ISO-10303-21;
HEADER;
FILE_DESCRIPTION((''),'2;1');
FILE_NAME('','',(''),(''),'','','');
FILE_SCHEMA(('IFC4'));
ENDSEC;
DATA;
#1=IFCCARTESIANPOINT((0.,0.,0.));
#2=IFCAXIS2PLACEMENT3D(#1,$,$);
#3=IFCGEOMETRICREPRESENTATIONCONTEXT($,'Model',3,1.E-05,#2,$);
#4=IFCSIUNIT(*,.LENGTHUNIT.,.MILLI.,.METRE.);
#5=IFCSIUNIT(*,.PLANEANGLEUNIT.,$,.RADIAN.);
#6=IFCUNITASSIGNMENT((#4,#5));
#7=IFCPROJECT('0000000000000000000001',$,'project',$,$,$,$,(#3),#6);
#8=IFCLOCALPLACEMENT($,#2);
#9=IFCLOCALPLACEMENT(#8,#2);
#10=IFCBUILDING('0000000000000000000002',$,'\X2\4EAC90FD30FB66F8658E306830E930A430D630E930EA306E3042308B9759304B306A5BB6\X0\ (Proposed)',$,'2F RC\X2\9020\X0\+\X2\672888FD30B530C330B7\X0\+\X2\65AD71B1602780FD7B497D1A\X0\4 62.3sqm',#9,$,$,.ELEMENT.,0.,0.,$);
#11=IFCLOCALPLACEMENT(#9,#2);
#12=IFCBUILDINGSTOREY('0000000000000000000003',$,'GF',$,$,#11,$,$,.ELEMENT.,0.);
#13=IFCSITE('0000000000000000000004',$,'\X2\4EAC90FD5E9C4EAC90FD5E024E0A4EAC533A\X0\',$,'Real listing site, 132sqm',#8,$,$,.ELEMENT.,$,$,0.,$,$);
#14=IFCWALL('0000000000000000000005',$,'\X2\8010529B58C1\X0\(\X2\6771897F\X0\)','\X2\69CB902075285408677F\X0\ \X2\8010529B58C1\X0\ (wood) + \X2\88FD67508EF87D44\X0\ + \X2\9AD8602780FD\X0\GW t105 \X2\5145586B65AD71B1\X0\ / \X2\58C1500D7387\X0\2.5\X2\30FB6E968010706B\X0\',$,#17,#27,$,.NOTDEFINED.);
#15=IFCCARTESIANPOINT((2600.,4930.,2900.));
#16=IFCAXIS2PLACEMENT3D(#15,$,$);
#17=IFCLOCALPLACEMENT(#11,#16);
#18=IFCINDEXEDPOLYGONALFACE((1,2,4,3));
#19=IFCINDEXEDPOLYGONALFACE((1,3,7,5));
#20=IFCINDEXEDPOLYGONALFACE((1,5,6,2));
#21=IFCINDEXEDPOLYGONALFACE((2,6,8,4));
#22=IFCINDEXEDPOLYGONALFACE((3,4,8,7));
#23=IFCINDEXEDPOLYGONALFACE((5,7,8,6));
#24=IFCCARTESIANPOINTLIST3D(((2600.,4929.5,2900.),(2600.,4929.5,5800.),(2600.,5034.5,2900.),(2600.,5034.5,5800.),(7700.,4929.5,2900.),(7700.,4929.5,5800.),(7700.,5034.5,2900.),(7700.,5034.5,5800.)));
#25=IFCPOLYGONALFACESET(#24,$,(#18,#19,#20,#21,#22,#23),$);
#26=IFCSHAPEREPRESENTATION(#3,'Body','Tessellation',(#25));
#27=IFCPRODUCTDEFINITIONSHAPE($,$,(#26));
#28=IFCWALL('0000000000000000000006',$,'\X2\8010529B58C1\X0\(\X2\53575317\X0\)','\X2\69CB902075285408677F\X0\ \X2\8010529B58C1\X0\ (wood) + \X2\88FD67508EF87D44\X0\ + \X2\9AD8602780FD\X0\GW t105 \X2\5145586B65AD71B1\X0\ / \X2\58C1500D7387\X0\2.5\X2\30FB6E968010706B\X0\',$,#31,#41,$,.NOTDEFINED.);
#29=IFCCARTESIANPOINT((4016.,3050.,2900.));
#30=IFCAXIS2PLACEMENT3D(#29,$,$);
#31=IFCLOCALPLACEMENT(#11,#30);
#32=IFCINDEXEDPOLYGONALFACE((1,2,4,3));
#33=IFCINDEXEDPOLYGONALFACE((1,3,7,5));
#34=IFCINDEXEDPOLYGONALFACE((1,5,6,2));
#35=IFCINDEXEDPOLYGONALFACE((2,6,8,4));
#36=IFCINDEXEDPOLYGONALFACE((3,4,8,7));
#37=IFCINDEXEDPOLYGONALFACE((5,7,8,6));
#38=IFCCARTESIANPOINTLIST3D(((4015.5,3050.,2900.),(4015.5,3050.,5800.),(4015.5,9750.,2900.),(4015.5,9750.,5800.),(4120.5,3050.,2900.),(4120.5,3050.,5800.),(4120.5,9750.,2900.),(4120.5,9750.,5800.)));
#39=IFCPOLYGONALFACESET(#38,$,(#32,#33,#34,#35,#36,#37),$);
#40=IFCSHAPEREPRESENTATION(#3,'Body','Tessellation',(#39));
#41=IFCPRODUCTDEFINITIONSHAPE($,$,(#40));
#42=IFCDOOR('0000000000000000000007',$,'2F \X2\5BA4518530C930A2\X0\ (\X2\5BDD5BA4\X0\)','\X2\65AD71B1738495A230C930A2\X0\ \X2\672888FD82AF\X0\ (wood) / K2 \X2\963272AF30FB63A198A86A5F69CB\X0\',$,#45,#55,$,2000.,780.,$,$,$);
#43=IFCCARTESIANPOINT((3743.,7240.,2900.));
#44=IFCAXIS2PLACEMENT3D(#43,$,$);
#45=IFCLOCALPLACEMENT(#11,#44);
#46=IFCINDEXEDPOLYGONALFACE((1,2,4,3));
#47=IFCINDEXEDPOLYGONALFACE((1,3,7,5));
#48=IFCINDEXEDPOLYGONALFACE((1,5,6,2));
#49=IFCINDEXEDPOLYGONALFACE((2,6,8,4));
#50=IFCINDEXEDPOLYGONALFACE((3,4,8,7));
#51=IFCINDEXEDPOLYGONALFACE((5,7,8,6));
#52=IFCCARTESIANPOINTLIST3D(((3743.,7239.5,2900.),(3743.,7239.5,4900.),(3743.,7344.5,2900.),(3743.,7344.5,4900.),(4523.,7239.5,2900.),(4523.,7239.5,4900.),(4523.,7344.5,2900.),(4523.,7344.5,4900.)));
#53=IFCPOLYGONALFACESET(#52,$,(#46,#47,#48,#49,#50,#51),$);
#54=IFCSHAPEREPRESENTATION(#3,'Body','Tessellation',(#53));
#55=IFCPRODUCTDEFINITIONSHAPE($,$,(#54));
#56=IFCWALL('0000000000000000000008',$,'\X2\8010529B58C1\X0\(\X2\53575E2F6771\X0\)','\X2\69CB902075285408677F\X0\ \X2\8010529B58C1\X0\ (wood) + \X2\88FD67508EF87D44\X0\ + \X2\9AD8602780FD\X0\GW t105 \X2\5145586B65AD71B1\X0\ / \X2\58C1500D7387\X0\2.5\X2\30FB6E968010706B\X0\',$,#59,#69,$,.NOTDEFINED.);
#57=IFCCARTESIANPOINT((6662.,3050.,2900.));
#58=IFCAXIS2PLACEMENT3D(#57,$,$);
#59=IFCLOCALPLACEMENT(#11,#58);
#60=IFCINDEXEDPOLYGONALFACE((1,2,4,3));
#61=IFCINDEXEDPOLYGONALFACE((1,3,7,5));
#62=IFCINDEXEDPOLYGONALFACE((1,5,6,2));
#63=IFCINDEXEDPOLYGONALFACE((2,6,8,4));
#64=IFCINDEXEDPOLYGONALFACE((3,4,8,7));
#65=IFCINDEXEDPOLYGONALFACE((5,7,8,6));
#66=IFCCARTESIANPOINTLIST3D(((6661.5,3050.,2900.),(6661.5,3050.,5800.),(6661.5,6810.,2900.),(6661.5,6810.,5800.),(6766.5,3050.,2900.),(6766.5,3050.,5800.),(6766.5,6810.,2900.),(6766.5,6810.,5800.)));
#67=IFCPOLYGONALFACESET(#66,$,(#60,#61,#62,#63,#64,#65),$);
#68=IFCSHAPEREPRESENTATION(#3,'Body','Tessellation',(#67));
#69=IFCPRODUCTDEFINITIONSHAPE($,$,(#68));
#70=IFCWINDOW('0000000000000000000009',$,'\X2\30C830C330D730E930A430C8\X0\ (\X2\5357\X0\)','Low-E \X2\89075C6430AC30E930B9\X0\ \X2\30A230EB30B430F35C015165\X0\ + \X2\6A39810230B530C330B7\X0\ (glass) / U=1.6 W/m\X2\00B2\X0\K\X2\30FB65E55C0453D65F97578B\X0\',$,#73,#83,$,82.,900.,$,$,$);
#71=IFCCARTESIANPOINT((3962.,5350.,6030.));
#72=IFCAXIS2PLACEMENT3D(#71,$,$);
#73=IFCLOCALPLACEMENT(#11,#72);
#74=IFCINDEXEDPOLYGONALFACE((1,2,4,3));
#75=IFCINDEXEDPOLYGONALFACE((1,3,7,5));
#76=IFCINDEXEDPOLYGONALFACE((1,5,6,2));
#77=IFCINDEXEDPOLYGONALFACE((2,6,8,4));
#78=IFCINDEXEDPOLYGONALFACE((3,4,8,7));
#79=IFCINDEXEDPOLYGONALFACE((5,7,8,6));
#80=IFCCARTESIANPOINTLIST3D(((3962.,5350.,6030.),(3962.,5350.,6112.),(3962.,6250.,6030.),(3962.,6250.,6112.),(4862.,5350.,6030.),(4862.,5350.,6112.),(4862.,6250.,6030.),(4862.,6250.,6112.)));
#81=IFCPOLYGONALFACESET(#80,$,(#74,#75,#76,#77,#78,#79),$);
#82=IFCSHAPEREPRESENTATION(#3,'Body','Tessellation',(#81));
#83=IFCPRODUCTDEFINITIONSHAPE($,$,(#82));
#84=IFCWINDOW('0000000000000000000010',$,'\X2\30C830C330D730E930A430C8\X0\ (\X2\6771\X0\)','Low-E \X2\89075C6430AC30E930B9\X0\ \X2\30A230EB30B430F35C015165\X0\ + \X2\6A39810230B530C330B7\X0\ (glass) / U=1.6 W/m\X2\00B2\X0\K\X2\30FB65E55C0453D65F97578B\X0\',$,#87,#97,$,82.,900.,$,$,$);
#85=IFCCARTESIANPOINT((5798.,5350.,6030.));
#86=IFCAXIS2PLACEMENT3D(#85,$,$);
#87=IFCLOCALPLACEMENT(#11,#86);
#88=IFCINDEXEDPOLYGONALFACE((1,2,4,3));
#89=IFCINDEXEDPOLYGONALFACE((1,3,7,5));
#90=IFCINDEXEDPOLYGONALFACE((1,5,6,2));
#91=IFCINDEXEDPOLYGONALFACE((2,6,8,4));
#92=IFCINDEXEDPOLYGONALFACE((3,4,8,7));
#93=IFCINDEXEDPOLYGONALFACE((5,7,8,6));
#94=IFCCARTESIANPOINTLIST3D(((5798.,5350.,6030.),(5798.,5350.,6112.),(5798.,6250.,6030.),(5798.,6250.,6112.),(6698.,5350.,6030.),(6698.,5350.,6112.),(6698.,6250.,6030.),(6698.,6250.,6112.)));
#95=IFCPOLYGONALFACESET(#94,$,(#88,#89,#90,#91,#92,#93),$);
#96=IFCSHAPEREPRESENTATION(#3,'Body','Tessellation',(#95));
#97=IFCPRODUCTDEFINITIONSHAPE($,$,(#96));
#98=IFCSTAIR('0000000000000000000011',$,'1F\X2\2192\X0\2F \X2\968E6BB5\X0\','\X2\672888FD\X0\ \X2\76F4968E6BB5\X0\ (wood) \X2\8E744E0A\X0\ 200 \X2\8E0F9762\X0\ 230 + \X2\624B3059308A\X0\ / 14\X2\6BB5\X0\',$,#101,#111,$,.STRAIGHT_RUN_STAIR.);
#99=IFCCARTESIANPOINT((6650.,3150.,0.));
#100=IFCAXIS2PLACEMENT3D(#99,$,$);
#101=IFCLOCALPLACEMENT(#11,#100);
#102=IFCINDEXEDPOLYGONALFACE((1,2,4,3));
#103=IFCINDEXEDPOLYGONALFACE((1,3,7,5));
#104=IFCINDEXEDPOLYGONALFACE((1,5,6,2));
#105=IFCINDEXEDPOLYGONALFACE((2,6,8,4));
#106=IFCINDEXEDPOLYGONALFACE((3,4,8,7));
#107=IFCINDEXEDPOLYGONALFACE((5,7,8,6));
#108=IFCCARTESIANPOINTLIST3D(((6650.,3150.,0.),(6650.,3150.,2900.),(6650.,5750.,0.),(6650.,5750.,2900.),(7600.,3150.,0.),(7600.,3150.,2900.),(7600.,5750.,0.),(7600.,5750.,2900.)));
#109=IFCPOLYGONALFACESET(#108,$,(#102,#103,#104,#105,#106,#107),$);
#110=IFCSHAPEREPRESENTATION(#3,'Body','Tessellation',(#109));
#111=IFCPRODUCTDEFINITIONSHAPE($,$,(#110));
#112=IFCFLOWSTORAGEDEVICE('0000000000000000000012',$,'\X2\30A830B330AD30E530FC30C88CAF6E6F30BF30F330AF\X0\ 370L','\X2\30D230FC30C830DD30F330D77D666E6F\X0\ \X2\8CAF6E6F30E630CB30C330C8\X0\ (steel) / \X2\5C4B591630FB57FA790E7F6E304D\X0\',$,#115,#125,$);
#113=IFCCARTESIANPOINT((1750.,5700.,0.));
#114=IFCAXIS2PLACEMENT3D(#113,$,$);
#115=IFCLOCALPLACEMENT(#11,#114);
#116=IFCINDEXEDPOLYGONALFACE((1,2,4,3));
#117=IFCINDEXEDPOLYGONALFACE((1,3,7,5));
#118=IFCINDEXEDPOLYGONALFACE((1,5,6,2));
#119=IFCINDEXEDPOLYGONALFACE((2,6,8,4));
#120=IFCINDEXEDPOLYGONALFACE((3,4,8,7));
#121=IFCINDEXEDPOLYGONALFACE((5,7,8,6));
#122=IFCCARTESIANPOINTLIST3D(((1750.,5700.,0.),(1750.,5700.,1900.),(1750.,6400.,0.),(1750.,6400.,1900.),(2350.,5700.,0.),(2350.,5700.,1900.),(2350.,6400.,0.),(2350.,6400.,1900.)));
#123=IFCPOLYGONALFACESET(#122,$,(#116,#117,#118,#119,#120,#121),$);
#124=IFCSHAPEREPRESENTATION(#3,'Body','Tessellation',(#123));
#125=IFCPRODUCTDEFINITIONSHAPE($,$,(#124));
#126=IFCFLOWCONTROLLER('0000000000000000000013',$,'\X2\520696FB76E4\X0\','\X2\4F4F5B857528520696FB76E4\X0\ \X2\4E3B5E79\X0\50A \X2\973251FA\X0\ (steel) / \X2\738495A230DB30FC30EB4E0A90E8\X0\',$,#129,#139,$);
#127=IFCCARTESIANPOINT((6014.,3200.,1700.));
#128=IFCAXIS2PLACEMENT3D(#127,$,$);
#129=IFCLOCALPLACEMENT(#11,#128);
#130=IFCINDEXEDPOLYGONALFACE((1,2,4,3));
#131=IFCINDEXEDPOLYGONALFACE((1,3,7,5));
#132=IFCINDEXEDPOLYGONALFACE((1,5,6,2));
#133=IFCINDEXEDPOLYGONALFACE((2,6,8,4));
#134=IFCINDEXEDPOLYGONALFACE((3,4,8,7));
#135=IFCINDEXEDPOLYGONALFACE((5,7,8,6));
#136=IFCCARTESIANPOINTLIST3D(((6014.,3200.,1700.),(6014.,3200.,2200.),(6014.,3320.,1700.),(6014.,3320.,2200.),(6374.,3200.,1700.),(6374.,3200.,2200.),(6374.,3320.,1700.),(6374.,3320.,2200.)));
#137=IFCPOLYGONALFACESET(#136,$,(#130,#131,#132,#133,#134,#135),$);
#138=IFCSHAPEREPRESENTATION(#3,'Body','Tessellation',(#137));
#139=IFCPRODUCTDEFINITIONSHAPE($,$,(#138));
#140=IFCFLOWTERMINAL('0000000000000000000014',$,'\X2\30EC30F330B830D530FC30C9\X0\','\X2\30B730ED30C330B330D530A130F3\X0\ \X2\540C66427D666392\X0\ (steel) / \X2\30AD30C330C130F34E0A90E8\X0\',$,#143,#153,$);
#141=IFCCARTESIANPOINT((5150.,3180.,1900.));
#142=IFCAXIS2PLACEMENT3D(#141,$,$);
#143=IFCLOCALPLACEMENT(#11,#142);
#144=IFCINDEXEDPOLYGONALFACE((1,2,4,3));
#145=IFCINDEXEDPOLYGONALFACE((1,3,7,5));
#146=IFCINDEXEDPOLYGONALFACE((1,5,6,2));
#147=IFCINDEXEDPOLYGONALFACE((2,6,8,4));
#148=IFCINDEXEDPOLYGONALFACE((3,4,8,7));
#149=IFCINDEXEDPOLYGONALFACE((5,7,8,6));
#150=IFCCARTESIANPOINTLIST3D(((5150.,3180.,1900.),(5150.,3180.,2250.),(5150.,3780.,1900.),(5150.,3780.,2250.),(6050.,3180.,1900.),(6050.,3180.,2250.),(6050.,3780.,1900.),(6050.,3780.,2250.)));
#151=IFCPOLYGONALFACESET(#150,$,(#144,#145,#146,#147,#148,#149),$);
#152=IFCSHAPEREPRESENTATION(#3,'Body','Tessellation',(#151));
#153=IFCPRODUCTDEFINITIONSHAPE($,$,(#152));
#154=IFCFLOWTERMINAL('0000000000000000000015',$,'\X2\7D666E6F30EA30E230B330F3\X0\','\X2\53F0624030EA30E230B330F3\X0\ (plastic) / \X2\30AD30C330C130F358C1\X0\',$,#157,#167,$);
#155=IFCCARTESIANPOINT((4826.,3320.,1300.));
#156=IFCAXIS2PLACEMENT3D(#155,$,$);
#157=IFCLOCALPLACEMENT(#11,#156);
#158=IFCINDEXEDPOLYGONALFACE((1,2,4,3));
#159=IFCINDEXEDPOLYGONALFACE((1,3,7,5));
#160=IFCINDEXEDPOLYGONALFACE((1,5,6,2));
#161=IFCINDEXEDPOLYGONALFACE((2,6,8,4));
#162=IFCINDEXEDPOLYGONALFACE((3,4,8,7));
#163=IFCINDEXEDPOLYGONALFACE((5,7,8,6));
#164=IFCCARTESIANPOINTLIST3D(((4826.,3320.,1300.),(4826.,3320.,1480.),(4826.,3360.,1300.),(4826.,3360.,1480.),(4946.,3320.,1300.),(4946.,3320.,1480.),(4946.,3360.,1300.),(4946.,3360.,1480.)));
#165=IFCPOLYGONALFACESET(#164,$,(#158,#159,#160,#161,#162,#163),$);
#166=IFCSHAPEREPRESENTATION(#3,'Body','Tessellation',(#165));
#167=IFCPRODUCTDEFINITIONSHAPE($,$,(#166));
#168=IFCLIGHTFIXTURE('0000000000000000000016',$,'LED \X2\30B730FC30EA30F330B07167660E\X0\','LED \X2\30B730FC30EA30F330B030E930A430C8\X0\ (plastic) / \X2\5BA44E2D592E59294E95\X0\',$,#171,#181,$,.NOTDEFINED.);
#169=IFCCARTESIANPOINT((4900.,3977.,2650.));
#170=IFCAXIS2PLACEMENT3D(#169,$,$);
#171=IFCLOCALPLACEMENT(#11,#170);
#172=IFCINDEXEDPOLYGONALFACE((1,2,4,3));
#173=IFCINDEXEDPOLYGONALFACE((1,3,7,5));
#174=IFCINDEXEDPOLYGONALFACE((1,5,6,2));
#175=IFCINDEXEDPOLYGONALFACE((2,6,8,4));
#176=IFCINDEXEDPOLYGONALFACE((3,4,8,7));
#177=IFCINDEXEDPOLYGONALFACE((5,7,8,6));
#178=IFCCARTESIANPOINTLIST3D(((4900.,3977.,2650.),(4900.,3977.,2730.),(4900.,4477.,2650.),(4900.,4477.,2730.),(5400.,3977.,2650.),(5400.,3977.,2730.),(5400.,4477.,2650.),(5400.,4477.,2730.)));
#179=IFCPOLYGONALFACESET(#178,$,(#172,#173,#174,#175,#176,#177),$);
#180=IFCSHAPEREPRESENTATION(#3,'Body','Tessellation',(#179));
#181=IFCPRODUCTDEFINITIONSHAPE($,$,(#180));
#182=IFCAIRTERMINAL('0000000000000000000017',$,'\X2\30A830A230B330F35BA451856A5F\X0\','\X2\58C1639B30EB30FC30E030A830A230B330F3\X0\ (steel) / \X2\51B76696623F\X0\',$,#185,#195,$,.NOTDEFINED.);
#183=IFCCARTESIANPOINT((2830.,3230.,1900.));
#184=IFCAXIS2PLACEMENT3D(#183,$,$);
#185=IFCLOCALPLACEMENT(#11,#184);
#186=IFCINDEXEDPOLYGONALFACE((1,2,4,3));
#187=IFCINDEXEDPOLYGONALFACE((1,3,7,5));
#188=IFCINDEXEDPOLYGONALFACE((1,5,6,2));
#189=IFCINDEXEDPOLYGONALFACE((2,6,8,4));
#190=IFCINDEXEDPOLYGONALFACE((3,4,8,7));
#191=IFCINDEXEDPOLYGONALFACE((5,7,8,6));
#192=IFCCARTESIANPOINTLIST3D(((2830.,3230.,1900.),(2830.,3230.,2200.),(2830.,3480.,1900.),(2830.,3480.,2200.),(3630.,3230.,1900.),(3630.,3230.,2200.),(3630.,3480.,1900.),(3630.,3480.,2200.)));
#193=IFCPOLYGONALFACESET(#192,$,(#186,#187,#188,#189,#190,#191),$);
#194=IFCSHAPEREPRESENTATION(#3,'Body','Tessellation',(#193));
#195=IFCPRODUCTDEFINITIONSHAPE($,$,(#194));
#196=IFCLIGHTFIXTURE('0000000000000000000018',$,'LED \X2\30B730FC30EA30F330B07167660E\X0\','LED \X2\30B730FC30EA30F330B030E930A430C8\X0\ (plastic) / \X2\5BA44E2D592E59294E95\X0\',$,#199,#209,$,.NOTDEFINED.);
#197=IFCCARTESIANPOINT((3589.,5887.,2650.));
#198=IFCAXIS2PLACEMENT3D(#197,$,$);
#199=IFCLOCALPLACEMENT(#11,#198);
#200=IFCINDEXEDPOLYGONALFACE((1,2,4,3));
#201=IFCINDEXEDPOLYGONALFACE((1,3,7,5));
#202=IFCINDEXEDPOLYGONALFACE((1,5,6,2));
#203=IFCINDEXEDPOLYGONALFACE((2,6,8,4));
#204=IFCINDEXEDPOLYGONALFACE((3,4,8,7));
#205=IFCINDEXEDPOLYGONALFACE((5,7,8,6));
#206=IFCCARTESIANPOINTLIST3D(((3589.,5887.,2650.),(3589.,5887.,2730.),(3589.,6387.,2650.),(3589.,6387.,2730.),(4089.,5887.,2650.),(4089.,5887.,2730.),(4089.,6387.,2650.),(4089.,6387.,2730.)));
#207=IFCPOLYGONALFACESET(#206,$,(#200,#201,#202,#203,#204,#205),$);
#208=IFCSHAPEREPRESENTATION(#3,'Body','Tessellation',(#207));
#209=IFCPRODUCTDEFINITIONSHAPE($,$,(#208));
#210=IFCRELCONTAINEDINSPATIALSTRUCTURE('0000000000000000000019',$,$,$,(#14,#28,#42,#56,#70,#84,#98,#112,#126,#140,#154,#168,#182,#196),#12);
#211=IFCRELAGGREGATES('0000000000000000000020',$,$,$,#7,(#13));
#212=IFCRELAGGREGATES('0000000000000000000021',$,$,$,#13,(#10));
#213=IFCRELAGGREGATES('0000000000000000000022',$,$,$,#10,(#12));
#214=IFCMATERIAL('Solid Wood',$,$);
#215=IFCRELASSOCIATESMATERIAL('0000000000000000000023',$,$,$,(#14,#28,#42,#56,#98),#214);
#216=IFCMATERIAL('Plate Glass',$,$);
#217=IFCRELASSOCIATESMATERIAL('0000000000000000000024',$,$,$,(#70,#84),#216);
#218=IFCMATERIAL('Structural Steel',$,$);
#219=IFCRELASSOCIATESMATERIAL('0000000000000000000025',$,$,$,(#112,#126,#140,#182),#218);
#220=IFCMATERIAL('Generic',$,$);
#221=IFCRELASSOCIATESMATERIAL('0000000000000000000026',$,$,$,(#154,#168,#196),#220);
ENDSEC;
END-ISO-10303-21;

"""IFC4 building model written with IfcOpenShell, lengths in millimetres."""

from ifc_helpers import new_model, si_unit, frame, frame_2d, origin, place, context, project, spatial, rectangle, extrude, material, element, fill, save


model = new_model("IFC4")

# Units and contexts
model_context = context("Model", 3, precision=1e-05, world=origin())
ifc_project = project(units=[si_unit("LENGTHUNIT", "METRE", prefix="MILLI"), si_unit("PLANEANGLEUNIT", "RADIAN")], contexts=[model_context])

# Site, building, storey
site_placement = place(None, origin())
site = spatial("IfcSite", under=ifc_project, at=site_placement, Name="京都府京都市上京区", ObjectType="Real listing site, 132sqm", CompositionType="ELEMENT", RefElevation=0.0)
building_placement = place(site_placement, origin())
building = spatial("IfcBuilding", under=site, at=building_placement, Name="京都・書斎とライブラリのある静かな家 (Proposed)", ObjectType="2F RC造+木製サッシ+断熱性能等級4 62.3sqm", CompositionType="ELEMENT", ElevationOfRefHeight=0.0, ElevationOfTerrain=0.0)
storey_placement = place(building_placement, origin())
storey = spatial("IfcBuildingStorey", under=building, at=storey_placement, Name="GF", CompositionType="ELEMENT", Elevation=0.0)

# Shared definitions
ifc_material_1 = material(Name="Solid Wood")

# Wall
wall_1_placement = place(storey_placement, frame((2600.0, 4930.0, 2900.0)))
element("IfcWall", 1, at=wall_1_placement, inside=storey, material=ifc_material_1, Name="耐力壁(東西)", Description="構造用合板 耐力壁 (wood) + 製材軸組 + 高性能GW t105 充填断熱 / 壁倍率2.5・準耐火", PredefinedType="NOTDEFINED", context=model_context, shape_type="SweptSolid", body=[
    extrude(rectangle(XDim=5100.0, YDim=105.0, at=frame_2d((2550.0, 52.0))), frame((2600.0, 4930.0, 2900.0)), (0.0, 0.0, 1.0), 2900.0),
])

# Wall, opening, door
wall_2_placement = place(storey_placement, frame((4016.0, 3050.0, 2900.0)))
wall_2 = element("IfcWall", 2, at=wall_2_placement, inside=storey, material=ifc_material_1, Name="耐力壁(南北)", Description="構造用合板 耐力壁 (wood) + 製材軸組 + 高性能GW t105 充填断熱 / 壁倍率2.5・準耐火", PredefinedType="NOTDEFINED", context=model_context, shape_type="SweptSolid", body=[
    extrude(rectangle(XDim=105.0, YDim=6700.0, at=frame_2d((52.0, 3350.0))), frame((4016.0, 3050.0, 2900.0)), (0.0, 0.0, 1.0), 2900.0),
])
opening_placement = place(storey_placement, frame((3743.0, 7240.0, 2900.0)))
opening = element("IfcOpeningElement", 3, at=opening_placement, cuts=wall_2, PredefinedType="NOTDEFINED", context=model_context, shape_type="SweptSolid", body=[
    extrude(rectangle(XDim=780.0, YDim=105.0, at=frame_2d((390.0, 52.0))), frame((3743.0, 7240.0, 2900.0)), (0.0, 0.0, 1.0), 2000.0),
])
door_placement = place(storey_placement, frame((3743.0, 7240.0, 2900.0)))
door = element("IfcDoor", 4, at=door_placement, inside=storey, material=ifc_material_1, Name="2F 室内ドア (寝室)", Description="断熱玄関ドア 木製芯 (wood) / K2 防犯・採風機構", OverallHeight=2000.0, OverallWidth=780.0, context=model_context, shape_type="SweptSolid", body=[
    extrude(rectangle(XDim=780.0, YDim=105.0, at=frame_2d((390.0, 52.0))), frame((3743.0, 7240.0, 2900.0)), (0.0, 0.0, 1.0), 2000.0),
])
fill(opening, door)

# Wall
wall_3_placement = place(storey_placement, frame((6662.0, 3050.0, 2900.0)))
element("IfcWall", 5, at=wall_3_placement, inside=storey, material=ifc_material_1, Name="耐力壁(南帯東)", Description="構造用合板 耐力壁 (wood) + 製材軸組 + 高性能GW t105 充填断熱 / 壁倍率2.5・準耐火", PredefinedType="NOTDEFINED", context=model_context, shape_type="SweptSolid", body=[
    extrude(rectangle(XDim=105.0, YDim=3760.0, at=frame_2d((52.0, 1880.0))), frame((6662.0, 3050.0, 2900.0)), (0.0, 0.0, 1.0), 2900.0),
])

# Windows
ifc_material_2 = material(Name="Plate Glass")
window_1_placement = place(storey_placement, frame((3962.0, 5350.0, 6030.0)))
element("IfcWindow", 6, at=window_1_placement, inside=storey, material=ifc_material_2, Name="トップライト (南)", Description="Low-E 複層ガラス アルゴン封入 + 樹脂サッシ (glass) / U=1.6 W/m²K・日射取得型", OverallHeight=82.0, OverallWidth=900.0, context=model_context, shape_type="SweptSolid", body=[
    extrude(rectangle(XDim=900.0, YDim=900.0, at=frame_2d((450.0, 450.0))), frame((3962.0, 5350.0, 6030.0)), (0.0, 0.0, 1.0), 82.0),
])
window_2_placement = place(storey_placement, frame((5798.0, 5350.0, 6030.0)))
element("IfcWindow", 7, at=window_2_placement, inside=storey, material=ifc_material_2, Name="トップライト (東)", Description="Low-E 複層ガラス アルゴン封入 + 樹脂サッシ (glass) / U=1.6 W/m²K・日射取得型", OverallHeight=82.0, OverallWidth=900.0, context=model_context, shape_type="SweptSolid", body=[
    extrude(rectangle(XDim=900.0, YDim=900.0, at=frame_2d((450.0, 450.0))), frame((5798.0, 5350.0, 6030.0)), (0.0, 0.0, 1.0), 82.0),
])

# Stair
stair_placement = place(storey_placement, frame((6650.0, 3150.0, 0.0)))
element("IfcStair", 8, at=stair_placement, inside=storey, material=ifc_material_1, Name="1F→2F 階段", Description="木製 直階段 (wood) 蹴上 200 踏面 230 + 手すり / 14段", PredefinedType="STRAIGHT_RUN_STAIR", context=model_context, shape_type="SweptSolid", body=[
    extrude(rectangle(XDim=950.0, YDim=2600.0, at=frame_2d((475.0, 1300.0))), frame((6650.0, 3150.0, 0.0)), (0.0, 0.0, 1.0), 2900.0),
])

# Flow storage device
ifc_material_3 = material(Name="Structural Steel")
flow_storage_device_placement = place(storey_placement, frame((1750.0, 5700.0, 0.0)))
element("IfcFlowStorageDevice", 9, at=flow_storage_device_placement, inside=storey, material=ifc_material_3, Name="エコキュート貯湯タンク 370L", Description="ヒートポンプ給湯 貯湯ユニット (steel) / 屋外・基礎置き", context=model_context, shape_type="SweptSolid", body=[
    extrude(rectangle(XDim=600.0, YDim=700.0, at=frame_2d((300.0, 350.0))), frame((1750.0, 5700.0, 0.0)), (0.0, 0.0, 1.0), 1900.0),
])

# Flow controller
flow_controller_placement = place(storey_placement, frame((6014.0, 3200.0, 1700.0)))
element("IfcFlowController", 10, at=flow_controller_placement, inside=storey, material=ifc_material_3, Name="分電盤", Description="住宅用分電盤 主幹50A 露出 (steel) / 玄関ホール上部", context=model_context, shape_type="SweptSolid", body=[
    extrude(rectangle(XDim=360.0, YDim=120.0, at=frame_2d((180.0, 60.0))), frame((6014.0, 3200.0, 1700.0)), (0.0, 0.0, 1.0), 500.0),
])

# Flow terminals
flow_terminal_1_placement = place(storey_placement, frame((5150.0, 3180.0, 1900.0)))
element("IfcFlowTerminal", 11, at=flow_terminal_1_placement, inside=storey, material=ifc_material_3, Name="レンジフード", Description="シロッコファン 同時給排 (steel) / キッチン上部", context=model_context, shape_type="SweptSolid", body=[
    extrude(rectangle(XDim=900.0, YDim=600.0, at=frame_2d((450.0, 300.0))), frame((5150.0, 3180.0, 1900.0)), (0.0, 0.0, 1.0), 350.0),
])
ifc_material_4 = material(Name="Generic")
flow_terminal_2_placement = place(storey_placement, frame((4826.0, 3320.0, 1300.0)))
element("IfcFlowTerminal", 12, at=flow_terminal_2_placement, inside=storey, material=ifc_material_4, Name="給湯リモコン", Description="台所リモコン (plastic) / キッチン壁", context=model_context, shape_type="SweptSolid", body=[
    extrude(rectangle(XDim=120.0, YDim=40.0, at=frame_2d((60.0, 20.0))), frame((4826.0, 3320.0, 1300.0)), (0.0, 0.0, 1.0), 180.0),
])

# Light fixture
light_fixture_1_placement = place(storey_placement, frame((4900.0, 3977.0, 2650.0)))
element("IfcLightFixture", 13, at=light_fixture_1_placement, inside=storey, material=ifc_material_4, Name="LED シーリング照明", Description="LED シーリングライト (plastic) / 室中央天井", PredefinedType="NOTDEFINED", context=model_context, shape_type="SweptSolid", body=[
    extrude(rectangle(XDim=500.0, YDim=500.0, at=frame_2d((250.0, 250.0))), frame((4900.0, 3977.0, 2650.0)), (0.0, 0.0, 1.0), 80.0),
])

# Air terminal
air_terminal_1_placement = place(storey_placement, frame((2830.0, 3230.0, 1900.0)))
element("IfcAirTerminal", 14, at=air_terminal_1_placement, inside=storey, material=ifc_material_3, Name="エアコン室内機", Description="壁掛ルームエアコン (steel) / 冷暖房", PredefinedType="NOTDEFINED", context=model_context, shape_type="SweptSolid", body=[
    extrude(rectangle(XDim=800.0, YDim=250.0, at=frame_2d((400.0, 125.0))), frame((2830.0, 3230.0, 1900.0)), (0.0, 0.0, 1.0), 300.0),
])

# Light fixture
light_fixture_2_placement = place(storey_placement, frame((3589.0, 5887.0, 2650.0)))
element("IfcLightFixture", 15, at=light_fixture_2_placement, inside=storey, material=ifc_material_4, Name="LED シーリング照明", Description="LED シーリングライト (plastic) / 室中央天井", PredefinedType="NOTDEFINED", context=model_context, shape_type="SweptSolid", body=[
    extrude(rectangle(XDim=500.0, YDim=500.0, at=frame_2d((250.0, 250.0))), frame((3589.0, 5887.0, 2650.0)), (0.0, 0.0, 1.0), 80.0),
])

save(model, "model.ifc")
